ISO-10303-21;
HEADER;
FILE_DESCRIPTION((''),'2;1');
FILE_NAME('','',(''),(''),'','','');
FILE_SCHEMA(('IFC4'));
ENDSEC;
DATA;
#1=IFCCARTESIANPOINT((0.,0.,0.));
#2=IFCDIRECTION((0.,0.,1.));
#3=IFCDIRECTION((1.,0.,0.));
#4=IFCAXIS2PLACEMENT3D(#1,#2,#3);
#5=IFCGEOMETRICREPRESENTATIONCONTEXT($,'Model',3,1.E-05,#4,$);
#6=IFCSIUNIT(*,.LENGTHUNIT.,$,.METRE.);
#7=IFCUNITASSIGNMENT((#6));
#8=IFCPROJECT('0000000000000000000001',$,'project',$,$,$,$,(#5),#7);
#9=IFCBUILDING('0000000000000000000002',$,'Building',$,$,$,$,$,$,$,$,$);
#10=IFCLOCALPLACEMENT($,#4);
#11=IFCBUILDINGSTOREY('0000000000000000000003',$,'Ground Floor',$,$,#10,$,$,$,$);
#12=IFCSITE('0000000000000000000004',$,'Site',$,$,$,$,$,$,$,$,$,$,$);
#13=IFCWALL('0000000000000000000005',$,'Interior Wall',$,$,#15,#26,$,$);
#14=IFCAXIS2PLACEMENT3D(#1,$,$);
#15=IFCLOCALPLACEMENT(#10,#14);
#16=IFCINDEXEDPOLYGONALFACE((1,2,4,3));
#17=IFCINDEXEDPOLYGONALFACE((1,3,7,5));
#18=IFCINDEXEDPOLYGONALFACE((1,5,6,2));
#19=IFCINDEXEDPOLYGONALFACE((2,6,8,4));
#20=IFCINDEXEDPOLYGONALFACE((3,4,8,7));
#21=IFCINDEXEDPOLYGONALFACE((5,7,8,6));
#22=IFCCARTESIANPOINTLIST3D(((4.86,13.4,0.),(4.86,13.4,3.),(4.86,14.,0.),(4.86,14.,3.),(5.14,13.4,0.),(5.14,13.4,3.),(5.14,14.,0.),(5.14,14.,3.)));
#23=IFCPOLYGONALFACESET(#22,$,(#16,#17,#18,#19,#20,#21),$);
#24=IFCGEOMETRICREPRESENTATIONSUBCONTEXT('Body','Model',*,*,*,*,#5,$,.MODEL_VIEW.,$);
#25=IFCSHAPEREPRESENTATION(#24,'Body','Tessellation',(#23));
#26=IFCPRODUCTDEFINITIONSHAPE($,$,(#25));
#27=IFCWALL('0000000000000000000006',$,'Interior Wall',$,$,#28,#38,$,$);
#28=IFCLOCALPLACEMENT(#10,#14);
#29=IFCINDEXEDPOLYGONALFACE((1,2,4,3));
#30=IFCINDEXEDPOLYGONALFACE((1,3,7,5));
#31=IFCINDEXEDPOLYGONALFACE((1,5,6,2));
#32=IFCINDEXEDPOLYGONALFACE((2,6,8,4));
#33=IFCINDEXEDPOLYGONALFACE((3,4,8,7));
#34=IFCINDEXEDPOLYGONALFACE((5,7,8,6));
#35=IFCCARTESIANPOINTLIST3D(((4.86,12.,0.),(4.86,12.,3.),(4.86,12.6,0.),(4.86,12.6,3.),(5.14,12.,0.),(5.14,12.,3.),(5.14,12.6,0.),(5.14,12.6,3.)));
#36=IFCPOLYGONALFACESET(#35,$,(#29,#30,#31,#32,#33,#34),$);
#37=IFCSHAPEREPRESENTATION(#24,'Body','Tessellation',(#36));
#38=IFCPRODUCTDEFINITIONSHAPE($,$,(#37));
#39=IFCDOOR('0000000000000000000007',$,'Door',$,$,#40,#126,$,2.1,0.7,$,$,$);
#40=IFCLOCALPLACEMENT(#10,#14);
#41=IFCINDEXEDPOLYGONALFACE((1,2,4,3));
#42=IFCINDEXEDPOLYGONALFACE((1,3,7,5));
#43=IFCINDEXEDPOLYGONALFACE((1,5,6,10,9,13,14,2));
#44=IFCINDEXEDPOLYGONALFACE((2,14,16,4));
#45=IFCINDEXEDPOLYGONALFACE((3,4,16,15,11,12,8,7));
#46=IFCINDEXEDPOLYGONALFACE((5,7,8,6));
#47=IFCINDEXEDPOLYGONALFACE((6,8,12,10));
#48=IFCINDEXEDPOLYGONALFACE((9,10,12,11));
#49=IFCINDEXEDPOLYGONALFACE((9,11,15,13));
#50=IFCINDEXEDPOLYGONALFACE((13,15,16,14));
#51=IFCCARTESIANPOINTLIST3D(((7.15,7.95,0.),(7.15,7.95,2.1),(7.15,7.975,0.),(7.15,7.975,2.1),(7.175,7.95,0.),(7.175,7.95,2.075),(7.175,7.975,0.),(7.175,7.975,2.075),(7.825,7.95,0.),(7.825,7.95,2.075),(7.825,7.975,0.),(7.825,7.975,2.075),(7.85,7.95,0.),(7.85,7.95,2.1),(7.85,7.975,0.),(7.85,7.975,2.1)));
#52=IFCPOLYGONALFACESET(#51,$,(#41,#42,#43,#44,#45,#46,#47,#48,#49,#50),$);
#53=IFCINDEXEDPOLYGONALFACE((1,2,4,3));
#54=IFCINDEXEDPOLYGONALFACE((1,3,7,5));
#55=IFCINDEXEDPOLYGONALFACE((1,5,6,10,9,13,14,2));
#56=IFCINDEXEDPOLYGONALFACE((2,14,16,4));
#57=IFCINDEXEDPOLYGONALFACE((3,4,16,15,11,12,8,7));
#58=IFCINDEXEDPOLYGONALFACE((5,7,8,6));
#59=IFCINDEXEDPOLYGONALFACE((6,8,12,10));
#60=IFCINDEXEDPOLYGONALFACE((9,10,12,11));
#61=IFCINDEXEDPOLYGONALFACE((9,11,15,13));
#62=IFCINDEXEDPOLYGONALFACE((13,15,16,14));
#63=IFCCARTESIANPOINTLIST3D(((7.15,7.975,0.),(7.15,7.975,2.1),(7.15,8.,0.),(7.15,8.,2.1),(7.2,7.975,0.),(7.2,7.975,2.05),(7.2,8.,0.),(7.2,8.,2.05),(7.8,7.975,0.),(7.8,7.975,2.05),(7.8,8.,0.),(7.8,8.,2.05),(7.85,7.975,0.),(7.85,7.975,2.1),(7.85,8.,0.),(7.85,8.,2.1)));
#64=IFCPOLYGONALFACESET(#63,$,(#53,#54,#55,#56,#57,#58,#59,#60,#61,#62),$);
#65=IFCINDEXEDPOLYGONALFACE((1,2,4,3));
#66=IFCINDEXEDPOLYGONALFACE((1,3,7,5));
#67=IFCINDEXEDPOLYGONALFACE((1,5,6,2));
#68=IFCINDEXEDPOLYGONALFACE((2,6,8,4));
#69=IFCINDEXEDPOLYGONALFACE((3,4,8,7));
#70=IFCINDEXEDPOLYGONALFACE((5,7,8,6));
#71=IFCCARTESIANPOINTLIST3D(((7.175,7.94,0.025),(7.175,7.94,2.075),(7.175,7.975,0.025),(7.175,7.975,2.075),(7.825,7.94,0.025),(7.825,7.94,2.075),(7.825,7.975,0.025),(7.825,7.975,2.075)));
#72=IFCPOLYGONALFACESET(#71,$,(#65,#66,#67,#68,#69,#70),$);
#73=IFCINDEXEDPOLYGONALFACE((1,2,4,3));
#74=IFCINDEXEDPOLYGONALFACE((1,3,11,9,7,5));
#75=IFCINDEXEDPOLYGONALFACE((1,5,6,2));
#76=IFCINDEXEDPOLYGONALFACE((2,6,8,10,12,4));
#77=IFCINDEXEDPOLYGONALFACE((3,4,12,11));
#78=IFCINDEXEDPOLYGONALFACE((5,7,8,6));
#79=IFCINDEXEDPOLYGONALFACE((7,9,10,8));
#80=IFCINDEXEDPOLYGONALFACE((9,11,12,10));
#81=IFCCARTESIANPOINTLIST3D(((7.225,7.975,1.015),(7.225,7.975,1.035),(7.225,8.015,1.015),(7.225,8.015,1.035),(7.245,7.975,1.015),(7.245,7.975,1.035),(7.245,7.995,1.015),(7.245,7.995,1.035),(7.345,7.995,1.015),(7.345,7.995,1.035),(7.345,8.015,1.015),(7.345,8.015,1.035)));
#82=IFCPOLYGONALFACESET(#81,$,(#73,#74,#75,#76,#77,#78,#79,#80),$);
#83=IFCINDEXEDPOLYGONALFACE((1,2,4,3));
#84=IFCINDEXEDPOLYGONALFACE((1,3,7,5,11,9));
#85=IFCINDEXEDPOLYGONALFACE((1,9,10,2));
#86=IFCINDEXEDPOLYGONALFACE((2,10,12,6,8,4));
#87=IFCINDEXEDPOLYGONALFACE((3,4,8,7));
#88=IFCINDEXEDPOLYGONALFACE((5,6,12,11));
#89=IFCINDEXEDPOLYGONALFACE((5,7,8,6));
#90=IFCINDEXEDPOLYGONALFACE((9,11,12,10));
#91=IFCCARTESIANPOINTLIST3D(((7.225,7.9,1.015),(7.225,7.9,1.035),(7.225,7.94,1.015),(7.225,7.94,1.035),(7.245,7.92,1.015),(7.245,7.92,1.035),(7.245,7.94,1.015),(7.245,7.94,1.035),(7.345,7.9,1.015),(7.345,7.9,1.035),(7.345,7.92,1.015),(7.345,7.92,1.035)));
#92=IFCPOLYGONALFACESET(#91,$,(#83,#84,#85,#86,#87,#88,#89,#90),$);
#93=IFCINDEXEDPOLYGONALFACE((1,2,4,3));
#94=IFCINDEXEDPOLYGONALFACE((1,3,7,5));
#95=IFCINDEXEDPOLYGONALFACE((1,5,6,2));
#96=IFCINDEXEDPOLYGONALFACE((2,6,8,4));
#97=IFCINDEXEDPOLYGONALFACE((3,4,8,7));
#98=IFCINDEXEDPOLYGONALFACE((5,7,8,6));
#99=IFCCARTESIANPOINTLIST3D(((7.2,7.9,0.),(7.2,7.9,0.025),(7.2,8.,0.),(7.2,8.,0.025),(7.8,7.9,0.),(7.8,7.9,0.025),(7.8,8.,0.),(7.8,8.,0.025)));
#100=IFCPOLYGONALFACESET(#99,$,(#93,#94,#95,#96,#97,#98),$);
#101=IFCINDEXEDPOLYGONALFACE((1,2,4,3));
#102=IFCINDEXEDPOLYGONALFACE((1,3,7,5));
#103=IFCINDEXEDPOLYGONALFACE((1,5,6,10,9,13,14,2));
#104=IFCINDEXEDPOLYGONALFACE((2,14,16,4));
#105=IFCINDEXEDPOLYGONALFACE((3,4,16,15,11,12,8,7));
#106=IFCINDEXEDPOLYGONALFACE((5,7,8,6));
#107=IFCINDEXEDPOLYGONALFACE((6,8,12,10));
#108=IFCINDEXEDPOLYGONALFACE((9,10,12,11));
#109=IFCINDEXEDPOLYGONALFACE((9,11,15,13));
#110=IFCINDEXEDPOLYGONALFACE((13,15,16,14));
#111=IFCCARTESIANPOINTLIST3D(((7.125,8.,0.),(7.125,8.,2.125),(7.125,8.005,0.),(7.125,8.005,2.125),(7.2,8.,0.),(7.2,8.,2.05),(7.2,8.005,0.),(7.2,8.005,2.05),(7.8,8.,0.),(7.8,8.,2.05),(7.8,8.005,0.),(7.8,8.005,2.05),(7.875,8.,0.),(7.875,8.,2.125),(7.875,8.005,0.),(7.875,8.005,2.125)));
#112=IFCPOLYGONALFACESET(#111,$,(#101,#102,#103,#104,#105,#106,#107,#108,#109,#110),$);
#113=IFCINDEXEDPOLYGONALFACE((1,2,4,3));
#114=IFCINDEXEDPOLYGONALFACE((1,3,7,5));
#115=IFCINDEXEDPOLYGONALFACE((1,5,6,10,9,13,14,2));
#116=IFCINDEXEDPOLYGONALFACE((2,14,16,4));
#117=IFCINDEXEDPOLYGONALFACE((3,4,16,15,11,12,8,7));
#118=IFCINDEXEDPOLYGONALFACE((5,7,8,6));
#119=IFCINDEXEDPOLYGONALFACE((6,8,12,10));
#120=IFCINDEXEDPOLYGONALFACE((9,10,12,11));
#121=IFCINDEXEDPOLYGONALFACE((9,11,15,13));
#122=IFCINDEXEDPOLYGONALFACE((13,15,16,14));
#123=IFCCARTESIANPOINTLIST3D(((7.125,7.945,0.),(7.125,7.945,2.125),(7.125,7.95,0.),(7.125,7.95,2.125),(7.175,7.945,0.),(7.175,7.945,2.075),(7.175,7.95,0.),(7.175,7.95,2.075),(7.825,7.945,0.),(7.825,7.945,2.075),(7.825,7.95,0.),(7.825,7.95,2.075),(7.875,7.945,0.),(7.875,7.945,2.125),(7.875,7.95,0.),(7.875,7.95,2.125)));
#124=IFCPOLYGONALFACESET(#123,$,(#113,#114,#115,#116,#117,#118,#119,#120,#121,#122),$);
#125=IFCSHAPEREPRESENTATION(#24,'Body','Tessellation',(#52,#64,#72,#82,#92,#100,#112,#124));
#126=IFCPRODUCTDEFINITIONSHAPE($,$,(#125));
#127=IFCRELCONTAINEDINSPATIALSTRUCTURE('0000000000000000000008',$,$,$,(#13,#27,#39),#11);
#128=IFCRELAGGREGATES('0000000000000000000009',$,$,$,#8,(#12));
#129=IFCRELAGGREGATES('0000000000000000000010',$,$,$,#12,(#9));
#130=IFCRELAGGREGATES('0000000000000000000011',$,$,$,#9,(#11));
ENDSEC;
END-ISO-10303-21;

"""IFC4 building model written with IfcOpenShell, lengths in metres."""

from ifc_helpers import new_model, si_unit, frame, origin_with_axes, place, context, subcontext, project, spatial, line, indexed_curve, outline, extrude, element, save


model = new_model("IFC4")

# Units and contexts
model_context = context("Model", 3, precision=1e-05, world=origin_with_axes())
body_context = subcontext(model_context, "Body", "Model", "MODEL_VIEW")
ifc_project = project(units=[si_unit("LENGTHUNIT", "METRE")], contexts=[model_context])

# Site, building, storey
site = spatial("IfcSite", under=ifc_project, Name="Site")
building = spatial("IfcBuilding", under=site, Name="Building")
storey_placement = place(None, origin_with_axes())
storey = spatial("IfcBuildingStorey", under=building, at=storey_placement, Name="Ground Floor")

# Walls
for number, where, z_axis, x_axis, name in (
    (1, (5.0, 14.0, 0.0), (0.0, 0.0, 1.0), (0.0, -1.0, 0.0), "Interior Wall"),
    (2, (5.0, 12.6, 0.0), (0.0, 0.0, 1.0), (0.0, -1.0, 0.0), "Interior Wall"),
):
    element("IfcWall", number, at=place(storey_placement, frame(where, z_axis=z_axis, x_axis=x_axis)), inside=storey, Name=name, context=body_context, shape_type="SweptSolid", body=[
        extrude(outline(indexed_curve([(0.0, 0.0), (0.0, 0.28), (0.6, 0.28), (0.6, 0.0), (0.0, 0.0)], self_intersect=False)), frame((0.0, -0.14, 0.0), z_axis=(0.0, 0.0, 1.0), x_axis=(1.0, 0.0, 0.0)), (0.0, 0.0, 1.0), 3.0),
    ])

# Door
door_1_placement = place(storey_placement, frame((7.85, 8.0, 0.0), z_axis=(0.0, 0.0, 1.0), x_axis=(-1.0, 0.0, 0.0)))
element("IfcDoor", 3, at=door_1_placement, inside=storey, Name="Door", OverallHeight=2.1, OverallWidth=0.7, context=body_context, shape_type="SweptSolid", body=[
    extrude(outline(indexed_curve([(0.0, 0.0), (0.0, 2.1), (0.7, 2.1), (0.7, 0.0), (0.675, 0.0), (0.675, 2.075), (0.025, 2.075), (0.025, 0.0)], segments=[line(1, 2, 3, 4, 5, 6, 7, 8, 1)])), frame((0.0, 0.025, 0.0), z_axis=(0.0, -1.0, 0.0), x_axis=(1.0, 0.0, 0.0)), (0.0, 0.0, -1.0), 0.025),
    extrude(outline(indexed_curve([(0.0, 0.0), (0.0, 2.1), (0.7, 2.1), (0.7, 0.0), (0.65, 0.0), (0.65, 2.05), (0.05, 2.05), (0.05, 0.0)], segments=[line(1, 2, 3, 4, 5, 6, 7, 8, 1)])), frame((0.0, 0.0, 0.0), z_axis=(0.0, -1.0, 0.0), x_axis=(1.0, 0.0, 0.0)), (0.0, 0.0, -1.0), 0.025),
    extrude(outline(indexed_curve([(0.0, 0.0), (0.65, 0.0), (0.65, 0.035), (0.0, 0.035)], segments=[line(1, 2, 3, 4, 1)])), frame((0.025, 0.025, 0.025), z_axis=(0.0, 0.0, 1.0), x_axis=(1.0, 0.0, 0.0)), (0.0, 0.0, 1.0), 2.05),
    extrude(outline(indexed_curve([(0.0, 0.0), (0.0, -0.04), (-0.12, -0.04), (-0.12, -0.02), (-0.02, -0.02), (-0.02, 0.0)], segments=[line(1, 2, 3, 4, 5, 6, 1)])), frame((0.625, 0.025, 1.015), z_axis=(0.0, 0.0, 1.0), x_axis=(1.0, 0.0, 0.0)), (0.0, 0.0, 1.0), 0.02),
    extrude(outline(indexed_curve([(0.0, 0.0), (0.0, 0.04), (-0.12, 0.04), (-0.12, 0.02), (-0.02, 0.02), (-0.02, 0.0)], segments=[line(1, 2, 3, 4, 5, 6, 1)])), frame((0.625, 0.06, 1.015), z_axis=(0.0, 0.0, 1.0), x_axis=(1.0, 0.0, 0.0)), (0.0, 0.0, 1.0), 0.02),
    extrude(outline(indexed_curve([(0.0, 0.0), (0.6, 0.0), (0.6, 0.1), (0.0, 0.1)], segments=[line(1, 2, 3, 4, 1)])), frame((0.05, 0.0, 0.0), z_axis=(0.0, 0.0, 1.0), x_axis=(1.0, 0.0, 0.0)), (0.0, 0.0, 1.0), 0.025),
    extrude(outline(indexed_curve([(0.0, 0.0), (0.0, 2.125), (0.75, 2.125), (0.75, 0.0), (0.675, 0.0), (0.675, 2.05), (0.075, 2.05), (0.075, 0.0)], segments=[line(1, 2, 3, 4, 5, 6, 7, 8, 1)])), frame((-0.025, -0.005, 0.0), z_axis=(0.0, -1.0, 0.0), x_axis=(1.0, 0.0, 0.0)), (0.0, 0.0, -1.0), 0.005),
    extrude(outline(indexed_curve([(0.0, 0.0), (0.0, 2.125), (0.75, 2.125), (0.75, 0.0), (0.7, 0.0), (0.7, 2.075), (0.05, 2.075), (0.05, 0.0)], segments=[line(1, 2, 3, 4, 5, 6, 7, 8, 1)])), frame((-0.025, 0.05, 0.0), z_axis=(0.0, -1.0, 0.0), x_axis=(1.0, 0.0, 0.0)), (0.0, 0.0, -1.0), 0.005),
])

save(model, "model.ifc")
